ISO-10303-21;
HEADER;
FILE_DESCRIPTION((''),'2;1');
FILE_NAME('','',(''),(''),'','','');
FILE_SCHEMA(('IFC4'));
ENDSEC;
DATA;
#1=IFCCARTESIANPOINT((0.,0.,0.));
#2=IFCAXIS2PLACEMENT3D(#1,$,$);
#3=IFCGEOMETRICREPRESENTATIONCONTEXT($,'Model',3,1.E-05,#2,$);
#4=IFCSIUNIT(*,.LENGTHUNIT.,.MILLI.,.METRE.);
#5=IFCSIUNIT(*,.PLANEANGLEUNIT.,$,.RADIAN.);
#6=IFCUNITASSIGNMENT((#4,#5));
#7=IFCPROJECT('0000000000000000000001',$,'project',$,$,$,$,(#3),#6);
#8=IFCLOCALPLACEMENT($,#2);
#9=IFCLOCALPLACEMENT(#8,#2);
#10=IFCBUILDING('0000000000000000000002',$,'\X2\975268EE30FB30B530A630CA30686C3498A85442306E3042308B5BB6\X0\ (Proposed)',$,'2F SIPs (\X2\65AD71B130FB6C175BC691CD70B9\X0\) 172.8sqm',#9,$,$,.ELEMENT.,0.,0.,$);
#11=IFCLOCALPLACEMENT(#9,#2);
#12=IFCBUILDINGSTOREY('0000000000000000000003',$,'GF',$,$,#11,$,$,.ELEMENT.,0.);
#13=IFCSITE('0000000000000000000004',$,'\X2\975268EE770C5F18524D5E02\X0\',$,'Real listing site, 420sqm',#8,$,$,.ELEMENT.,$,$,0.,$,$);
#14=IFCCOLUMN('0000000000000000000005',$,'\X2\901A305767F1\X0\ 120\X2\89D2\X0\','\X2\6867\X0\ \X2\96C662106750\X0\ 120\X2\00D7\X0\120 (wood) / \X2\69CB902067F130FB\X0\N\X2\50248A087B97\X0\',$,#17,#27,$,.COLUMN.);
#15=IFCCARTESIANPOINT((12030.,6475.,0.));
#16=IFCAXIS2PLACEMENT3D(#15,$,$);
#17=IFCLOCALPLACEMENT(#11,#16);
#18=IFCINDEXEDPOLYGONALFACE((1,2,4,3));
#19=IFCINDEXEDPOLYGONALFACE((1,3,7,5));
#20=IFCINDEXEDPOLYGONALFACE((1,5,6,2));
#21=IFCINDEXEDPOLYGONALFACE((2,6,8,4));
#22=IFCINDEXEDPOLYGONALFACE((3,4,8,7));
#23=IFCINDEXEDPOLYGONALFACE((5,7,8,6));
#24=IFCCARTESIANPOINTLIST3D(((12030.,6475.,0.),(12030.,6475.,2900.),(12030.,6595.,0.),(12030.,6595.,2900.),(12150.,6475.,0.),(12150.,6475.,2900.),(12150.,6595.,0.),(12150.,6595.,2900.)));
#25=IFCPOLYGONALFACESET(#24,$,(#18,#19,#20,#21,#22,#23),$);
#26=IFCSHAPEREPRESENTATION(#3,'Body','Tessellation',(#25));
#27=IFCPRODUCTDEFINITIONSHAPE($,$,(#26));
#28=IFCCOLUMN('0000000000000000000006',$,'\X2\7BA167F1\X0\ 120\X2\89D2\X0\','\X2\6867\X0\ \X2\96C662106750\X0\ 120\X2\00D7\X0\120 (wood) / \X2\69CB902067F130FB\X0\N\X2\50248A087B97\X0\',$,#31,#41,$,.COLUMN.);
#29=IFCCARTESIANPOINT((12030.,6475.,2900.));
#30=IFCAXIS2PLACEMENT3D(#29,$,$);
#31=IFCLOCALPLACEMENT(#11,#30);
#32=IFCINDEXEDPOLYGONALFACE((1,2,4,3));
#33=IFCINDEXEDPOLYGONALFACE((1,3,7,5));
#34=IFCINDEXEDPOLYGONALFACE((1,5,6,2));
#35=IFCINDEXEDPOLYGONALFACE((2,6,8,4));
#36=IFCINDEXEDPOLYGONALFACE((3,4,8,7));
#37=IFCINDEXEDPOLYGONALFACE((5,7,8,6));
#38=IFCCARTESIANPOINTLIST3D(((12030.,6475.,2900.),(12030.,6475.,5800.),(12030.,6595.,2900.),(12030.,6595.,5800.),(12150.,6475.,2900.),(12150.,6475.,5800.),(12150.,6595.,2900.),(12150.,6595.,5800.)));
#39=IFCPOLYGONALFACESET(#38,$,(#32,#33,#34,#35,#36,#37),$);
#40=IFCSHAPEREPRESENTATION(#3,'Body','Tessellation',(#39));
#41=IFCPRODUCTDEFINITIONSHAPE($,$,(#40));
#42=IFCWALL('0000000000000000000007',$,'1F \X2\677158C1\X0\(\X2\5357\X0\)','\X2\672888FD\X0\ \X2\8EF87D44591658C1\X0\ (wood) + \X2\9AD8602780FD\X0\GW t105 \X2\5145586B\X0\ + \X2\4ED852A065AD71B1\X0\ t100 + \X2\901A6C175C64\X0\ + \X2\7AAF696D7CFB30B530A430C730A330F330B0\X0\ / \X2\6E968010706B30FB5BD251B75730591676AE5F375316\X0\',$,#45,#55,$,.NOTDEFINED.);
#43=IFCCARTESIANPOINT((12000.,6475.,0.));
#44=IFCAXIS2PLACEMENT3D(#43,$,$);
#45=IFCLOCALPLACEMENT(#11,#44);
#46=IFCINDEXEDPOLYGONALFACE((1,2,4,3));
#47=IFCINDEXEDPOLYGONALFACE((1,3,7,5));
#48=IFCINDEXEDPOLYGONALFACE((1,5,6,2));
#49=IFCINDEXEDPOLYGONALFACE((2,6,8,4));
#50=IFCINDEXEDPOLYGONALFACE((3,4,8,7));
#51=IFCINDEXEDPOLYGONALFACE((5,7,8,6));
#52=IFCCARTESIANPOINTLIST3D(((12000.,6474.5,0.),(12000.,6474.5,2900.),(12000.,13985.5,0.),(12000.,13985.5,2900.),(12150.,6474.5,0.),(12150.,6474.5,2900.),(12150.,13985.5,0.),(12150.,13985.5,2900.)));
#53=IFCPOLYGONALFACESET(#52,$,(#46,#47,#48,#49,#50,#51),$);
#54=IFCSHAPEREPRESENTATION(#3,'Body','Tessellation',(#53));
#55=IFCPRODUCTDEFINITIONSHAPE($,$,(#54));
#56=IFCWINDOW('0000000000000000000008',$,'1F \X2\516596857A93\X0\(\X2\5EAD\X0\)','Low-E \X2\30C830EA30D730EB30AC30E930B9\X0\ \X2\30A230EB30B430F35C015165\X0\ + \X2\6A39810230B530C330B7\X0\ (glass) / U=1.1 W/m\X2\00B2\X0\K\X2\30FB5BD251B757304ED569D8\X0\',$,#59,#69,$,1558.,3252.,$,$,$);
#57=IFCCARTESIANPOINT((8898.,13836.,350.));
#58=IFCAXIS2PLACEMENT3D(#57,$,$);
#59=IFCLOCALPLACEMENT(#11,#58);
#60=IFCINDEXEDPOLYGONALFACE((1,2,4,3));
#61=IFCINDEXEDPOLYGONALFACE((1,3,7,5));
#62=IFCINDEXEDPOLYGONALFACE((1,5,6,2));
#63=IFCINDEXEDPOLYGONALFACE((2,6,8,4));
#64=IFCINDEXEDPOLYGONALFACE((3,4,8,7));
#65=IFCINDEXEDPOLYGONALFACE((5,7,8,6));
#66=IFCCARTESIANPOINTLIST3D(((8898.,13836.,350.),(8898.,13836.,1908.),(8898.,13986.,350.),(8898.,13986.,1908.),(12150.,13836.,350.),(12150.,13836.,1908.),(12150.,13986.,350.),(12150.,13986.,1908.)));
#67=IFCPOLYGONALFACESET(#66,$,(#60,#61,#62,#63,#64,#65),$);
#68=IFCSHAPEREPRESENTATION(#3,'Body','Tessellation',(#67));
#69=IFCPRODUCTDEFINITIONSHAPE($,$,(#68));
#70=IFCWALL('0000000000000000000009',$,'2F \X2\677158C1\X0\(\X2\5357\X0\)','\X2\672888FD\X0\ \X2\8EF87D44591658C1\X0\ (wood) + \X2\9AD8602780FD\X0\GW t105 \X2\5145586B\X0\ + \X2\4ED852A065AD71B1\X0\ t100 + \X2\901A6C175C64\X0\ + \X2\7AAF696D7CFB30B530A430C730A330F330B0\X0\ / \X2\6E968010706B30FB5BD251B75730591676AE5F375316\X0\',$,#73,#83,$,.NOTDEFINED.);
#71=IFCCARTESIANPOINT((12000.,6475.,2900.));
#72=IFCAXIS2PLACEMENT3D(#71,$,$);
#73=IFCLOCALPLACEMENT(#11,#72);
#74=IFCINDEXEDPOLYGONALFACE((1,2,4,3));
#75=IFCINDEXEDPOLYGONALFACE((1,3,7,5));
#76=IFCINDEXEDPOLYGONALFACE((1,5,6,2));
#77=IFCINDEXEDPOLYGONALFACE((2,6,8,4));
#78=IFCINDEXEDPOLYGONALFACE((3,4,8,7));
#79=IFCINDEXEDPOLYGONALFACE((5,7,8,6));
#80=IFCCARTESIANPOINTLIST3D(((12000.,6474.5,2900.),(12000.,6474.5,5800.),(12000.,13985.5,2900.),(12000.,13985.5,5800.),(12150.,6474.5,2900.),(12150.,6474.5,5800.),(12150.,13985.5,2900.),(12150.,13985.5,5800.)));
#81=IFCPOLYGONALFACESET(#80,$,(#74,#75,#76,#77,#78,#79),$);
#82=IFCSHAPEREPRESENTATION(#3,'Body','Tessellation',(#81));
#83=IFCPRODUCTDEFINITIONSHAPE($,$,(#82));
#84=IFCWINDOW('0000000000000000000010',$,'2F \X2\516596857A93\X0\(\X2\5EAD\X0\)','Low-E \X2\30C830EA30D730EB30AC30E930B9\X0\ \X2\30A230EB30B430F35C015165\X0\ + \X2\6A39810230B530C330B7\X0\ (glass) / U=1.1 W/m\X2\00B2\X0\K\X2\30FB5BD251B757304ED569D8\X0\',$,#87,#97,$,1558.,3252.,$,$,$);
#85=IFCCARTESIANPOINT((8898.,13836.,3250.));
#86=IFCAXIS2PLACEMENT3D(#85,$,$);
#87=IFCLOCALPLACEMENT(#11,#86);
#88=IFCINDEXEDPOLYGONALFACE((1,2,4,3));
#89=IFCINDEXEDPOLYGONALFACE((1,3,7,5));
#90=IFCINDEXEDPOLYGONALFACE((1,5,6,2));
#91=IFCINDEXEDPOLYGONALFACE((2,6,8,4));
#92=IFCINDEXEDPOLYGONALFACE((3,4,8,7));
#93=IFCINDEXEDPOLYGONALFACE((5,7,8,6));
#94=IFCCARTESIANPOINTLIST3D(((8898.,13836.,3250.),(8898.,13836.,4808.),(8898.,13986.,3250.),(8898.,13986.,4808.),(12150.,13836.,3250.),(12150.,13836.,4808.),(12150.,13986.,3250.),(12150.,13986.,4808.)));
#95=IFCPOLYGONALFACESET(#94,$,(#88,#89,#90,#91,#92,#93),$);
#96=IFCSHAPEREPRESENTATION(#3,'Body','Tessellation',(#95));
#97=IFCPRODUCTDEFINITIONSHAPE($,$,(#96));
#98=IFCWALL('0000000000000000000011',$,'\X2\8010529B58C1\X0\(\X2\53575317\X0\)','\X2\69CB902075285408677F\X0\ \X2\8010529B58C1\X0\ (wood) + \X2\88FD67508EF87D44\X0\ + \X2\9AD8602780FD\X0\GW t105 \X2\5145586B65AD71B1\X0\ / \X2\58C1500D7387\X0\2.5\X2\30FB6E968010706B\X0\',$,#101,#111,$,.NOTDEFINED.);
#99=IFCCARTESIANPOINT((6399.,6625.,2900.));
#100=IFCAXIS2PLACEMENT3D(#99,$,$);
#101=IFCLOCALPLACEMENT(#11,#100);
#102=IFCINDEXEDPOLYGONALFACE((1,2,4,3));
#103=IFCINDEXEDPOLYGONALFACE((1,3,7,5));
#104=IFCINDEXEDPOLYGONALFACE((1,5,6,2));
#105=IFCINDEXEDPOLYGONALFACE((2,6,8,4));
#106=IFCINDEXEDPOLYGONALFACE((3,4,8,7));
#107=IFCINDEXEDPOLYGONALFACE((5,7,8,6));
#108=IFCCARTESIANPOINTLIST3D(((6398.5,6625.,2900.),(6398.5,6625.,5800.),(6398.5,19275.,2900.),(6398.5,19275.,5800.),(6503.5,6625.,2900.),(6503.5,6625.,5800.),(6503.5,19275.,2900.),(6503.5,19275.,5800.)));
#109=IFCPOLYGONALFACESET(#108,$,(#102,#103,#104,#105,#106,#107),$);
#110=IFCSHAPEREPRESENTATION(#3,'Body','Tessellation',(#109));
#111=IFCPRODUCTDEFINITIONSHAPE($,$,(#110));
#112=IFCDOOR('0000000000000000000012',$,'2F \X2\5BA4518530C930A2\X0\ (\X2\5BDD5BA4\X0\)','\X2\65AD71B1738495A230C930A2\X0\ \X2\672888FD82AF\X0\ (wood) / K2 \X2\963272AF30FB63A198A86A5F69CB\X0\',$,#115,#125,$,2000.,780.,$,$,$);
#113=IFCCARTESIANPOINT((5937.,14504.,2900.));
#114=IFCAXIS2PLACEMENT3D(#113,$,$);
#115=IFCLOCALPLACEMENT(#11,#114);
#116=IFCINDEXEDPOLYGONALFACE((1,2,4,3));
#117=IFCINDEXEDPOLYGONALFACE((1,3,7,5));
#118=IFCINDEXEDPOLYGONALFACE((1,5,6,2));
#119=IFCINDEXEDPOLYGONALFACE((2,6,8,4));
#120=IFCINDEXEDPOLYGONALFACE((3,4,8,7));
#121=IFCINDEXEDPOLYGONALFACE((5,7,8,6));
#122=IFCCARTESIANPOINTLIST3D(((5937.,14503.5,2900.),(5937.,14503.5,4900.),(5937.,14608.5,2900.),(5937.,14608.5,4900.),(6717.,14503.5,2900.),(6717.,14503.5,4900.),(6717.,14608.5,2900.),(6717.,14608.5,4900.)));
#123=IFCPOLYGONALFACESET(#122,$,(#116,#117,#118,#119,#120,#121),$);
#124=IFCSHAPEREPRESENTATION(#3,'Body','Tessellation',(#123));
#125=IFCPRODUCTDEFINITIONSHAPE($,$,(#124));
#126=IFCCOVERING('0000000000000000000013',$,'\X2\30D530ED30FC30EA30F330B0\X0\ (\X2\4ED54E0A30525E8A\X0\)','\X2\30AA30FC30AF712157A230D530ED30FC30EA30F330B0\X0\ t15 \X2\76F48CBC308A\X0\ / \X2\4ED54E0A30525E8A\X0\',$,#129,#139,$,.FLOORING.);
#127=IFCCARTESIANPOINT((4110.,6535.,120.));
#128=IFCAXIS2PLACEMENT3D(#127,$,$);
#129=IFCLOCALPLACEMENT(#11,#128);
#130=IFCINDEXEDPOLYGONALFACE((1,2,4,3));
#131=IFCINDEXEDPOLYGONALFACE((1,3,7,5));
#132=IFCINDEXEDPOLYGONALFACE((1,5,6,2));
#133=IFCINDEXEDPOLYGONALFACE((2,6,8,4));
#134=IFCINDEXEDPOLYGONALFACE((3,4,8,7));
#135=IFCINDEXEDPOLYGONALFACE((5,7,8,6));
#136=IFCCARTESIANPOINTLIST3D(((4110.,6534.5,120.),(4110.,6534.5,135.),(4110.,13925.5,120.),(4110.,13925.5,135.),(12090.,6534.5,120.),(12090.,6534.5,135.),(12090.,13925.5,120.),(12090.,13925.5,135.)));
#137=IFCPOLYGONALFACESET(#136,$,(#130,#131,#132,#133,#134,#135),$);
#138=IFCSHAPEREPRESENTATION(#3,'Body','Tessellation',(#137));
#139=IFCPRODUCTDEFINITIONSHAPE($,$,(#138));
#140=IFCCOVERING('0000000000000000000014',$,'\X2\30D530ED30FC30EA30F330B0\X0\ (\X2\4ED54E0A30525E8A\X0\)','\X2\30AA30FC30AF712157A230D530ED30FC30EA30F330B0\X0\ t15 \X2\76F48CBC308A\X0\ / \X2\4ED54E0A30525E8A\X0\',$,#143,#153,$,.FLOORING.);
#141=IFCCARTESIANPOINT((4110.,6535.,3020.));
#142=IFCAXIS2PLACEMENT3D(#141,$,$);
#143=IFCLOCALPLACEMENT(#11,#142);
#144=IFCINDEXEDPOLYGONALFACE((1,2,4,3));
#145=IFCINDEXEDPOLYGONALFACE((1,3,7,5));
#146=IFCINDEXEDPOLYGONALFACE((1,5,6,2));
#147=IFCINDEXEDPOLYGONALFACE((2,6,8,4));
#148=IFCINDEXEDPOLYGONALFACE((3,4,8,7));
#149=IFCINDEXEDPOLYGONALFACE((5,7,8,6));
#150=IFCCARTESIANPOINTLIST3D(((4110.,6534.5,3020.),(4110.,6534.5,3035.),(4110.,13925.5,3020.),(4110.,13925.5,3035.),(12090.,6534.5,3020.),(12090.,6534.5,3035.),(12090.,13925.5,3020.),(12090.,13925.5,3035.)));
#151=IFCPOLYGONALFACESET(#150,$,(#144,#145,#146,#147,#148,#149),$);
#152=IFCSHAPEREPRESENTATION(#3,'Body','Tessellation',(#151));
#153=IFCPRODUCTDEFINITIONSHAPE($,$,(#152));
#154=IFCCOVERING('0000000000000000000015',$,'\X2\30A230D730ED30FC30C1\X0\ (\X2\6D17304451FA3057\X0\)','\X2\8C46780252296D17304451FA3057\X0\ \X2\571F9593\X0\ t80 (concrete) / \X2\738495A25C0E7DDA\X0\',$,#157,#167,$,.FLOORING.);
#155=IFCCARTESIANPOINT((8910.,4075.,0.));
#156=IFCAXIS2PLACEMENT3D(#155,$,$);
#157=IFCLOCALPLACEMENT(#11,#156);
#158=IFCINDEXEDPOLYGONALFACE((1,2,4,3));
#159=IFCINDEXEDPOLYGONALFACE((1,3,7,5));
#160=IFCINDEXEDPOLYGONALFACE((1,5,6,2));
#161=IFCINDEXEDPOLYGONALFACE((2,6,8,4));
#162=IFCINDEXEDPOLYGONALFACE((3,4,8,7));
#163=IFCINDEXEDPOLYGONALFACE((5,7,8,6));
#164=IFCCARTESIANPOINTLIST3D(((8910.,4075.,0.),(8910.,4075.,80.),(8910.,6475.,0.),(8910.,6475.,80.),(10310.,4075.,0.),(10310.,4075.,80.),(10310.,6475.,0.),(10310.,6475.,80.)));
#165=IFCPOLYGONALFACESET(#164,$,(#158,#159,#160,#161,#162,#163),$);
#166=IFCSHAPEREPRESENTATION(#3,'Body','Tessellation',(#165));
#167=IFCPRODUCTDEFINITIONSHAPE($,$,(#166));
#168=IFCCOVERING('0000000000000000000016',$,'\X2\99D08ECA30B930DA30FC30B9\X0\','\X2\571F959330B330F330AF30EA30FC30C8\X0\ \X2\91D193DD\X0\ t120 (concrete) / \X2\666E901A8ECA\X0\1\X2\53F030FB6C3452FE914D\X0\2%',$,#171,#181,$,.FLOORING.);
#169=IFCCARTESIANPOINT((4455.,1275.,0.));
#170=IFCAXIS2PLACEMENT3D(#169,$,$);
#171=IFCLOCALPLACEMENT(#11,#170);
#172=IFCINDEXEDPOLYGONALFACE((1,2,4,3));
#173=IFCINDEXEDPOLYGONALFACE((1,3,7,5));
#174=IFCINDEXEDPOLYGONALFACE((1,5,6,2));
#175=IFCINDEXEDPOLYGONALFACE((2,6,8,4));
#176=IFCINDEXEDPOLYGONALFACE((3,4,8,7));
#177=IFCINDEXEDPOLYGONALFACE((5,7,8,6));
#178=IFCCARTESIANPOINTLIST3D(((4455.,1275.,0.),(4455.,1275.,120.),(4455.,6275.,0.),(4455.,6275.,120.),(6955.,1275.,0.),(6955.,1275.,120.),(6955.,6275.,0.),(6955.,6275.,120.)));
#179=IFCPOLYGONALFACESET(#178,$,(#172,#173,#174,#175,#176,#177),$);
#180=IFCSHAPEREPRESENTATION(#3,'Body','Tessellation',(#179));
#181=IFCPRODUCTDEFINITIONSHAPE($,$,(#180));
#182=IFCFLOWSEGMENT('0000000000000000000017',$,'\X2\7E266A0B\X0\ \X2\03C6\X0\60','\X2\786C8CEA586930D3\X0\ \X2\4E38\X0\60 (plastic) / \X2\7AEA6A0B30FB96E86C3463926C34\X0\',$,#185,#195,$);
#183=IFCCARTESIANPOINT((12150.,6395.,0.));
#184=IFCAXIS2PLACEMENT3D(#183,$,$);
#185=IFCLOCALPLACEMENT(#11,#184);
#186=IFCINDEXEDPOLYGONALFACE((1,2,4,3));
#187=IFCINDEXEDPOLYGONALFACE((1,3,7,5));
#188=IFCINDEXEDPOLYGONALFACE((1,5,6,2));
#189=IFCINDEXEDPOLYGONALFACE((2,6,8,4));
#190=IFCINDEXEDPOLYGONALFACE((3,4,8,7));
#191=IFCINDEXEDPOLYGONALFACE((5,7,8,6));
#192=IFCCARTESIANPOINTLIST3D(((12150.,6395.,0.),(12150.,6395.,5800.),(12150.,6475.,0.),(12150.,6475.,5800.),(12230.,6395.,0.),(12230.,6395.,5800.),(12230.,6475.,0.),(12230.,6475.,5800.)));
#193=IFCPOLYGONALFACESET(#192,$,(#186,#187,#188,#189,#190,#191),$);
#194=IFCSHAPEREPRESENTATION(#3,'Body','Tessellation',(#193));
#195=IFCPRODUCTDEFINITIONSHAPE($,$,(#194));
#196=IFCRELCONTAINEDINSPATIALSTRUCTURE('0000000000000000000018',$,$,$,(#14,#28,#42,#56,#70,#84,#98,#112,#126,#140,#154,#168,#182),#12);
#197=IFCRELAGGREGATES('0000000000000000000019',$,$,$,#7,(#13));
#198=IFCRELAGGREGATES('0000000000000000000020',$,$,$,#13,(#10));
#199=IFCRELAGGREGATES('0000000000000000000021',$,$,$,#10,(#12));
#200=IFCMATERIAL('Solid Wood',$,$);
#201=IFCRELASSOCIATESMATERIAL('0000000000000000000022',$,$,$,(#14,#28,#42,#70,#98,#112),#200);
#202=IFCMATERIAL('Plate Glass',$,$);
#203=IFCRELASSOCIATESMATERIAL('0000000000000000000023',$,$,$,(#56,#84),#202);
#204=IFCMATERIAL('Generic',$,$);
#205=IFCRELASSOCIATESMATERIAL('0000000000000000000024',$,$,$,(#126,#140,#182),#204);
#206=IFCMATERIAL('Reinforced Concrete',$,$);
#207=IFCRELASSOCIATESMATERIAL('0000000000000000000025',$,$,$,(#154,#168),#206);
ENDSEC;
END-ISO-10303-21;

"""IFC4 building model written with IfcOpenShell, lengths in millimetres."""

from ifc_helpers import new_model, si_unit, frame, frame_2d, origin, place, context, project, spatial, rectangle, extrude, material, element, fill, save


model = new_model("IFC4")

# Units and contexts
model_context = context("Model", 3, precision=1e-05, world=origin())
ifc_project = project(units=[si_unit("LENGTHUNIT", "METRE", prefix="MILLI"), si_unit("PLANEANGLEUNIT", "RADIAN")], contexts=[model_context])

# Site, building, storey
site_placement = place(None, origin())
site = spatial("IfcSite", under=ifc_project, at=site_placement, Name="青森県弘前市", ObjectType="Real listing site, 420sqm", CompositionType="ELEMENT", RefElevation=0.0)
building_placement = place(site_placement, origin())
building = spatial("IfcBuilding", under=site, at=building_placement, Name="青森・サウナと水風呂のある家 (Proposed)", ObjectType="2F SIPs (断熱・気密重点) 172.8sqm", CompositionType="ELEMENT", ElevationOfRefHeight=0.0, ElevationOfTerrain=0.0)
storey_placement = place(building_placement, origin())
storey = spatial("IfcBuildingStorey", under=building, at=storey_placement, Name="GF", CompositionType="ELEMENT", Elevation=0.0)

# Columns
ifc_material_1 = material(Name="Solid Wood")
column_1_placement = place(storey_placement, frame((12030.0, 6475.0, 0.0)))
element("IfcColumn", 1, at=column_1_placement, inside=storey, material=ifc_material_1, Name="通し柱 120角", Description="桧 集成材 120×120 (wood) / 構造柱・N値計算", PredefinedType="COLUMN", context=model_context, shape_type="SweptSolid", body=[
    extrude(rectangle(XDim=120.0, YDim=120.0, at=frame_2d((60.0, 60.0))), frame((12030.0, 6475.0, 0.0)), (0.0, 0.0, 1.0), 2900.0),
])
column_2_placement = place(storey_placement, frame((12030.0, 6475.0, 2900.0)))
element("IfcColumn", 2, at=column_2_placement, inside=storey, material=ifc_material_1, Name="管柱 120角", Description="桧 集成材 120×120 (wood) / 構造柱・N値計算", PredefinedType="COLUMN", context=model_context, shape_type="SweptSolid", body=[
    extrude(rectangle(XDim=120.0, YDim=120.0, at=frame_2d((60.0, 60.0))), frame((12030.0, 6475.0, 2900.0)), (0.0, 0.0, 1.0), 2900.0),
])

# Wall, opening, window
wall_1_placement = place(storey_placement, frame((12000.0, 6475.0, 0.0)))
wall_1 = element("IfcWall", 3, at=wall_1_placement, inside=storey, material=ifc_material_1, Name="1F 東壁(南)", Description="木製 軸組外壁 (wood) + 高性能GW t105 充填 + 付加断熱 t100 + 通気層 + 窯業系サイディング / 準耐火・寒冷地外皮強化", PredefinedType="NOTDEFINED", context=model_context, shape_type="SweptSolid", body=[
    extrude(rectangle(XDim=150.0, YDim=7511.0, at=frame_2d((75.0, 3755.0))), frame((12000.0, 6475.0, 0.0)), (0.0, 0.0, 1.0), 2900.0),
])
opening_1_placement = place(storey_placement, frame((8898.0, 13836.0, 350.0)))
opening_1 = element("IfcOpeningElement", 4, at=opening_1_placement, cuts=wall_1, PredefinedType="NOTDEFINED", context=model_context, shape_type="SweptSolid", body=[
    extrude(rectangle(XDim=3252.0, YDim=150.0, at=frame_2d((1626.0, 75.0))), frame((8898.0, 13836.0, 350.0)), (0.0, 0.0, 1.0), 1558.0),
])
ifc_material_2 = material(Name="Plate Glass")
window_1_placement = place(storey_placement, frame((8898.0, 13836.0, 350.0)))
window_1 = element("IfcWindow", 5, at=window_1_placement, inside=storey, material=ifc_material_2, Name="1F 入隅窓(庭)", Description="Low-E トリプルガラス アルゴン封入 + 樹脂サッシ (glass) / U=1.1 W/m²K・寒冷地仕様", OverallHeight=1558.0, OverallWidth=3252.0, context=model_context, shape_type="SweptSolid", body=[
    extrude(rectangle(XDim=3252.0, YDim=150.0, at=frame_2d((1626.0, 75.0))), frame((8898.0, 13836.0, 350.0)), (0.0, 0.0, 1.0), 1558.0),
])
fill(opening_1, window_1)

# Wall, opening, window
wall_2_placement = place(storey_placement, frame((12000.0, 6475.0, 2900.0)))
wall_2 = element("IfcWall", 6, at=wall_2_placement, inside=storey, material=ifc_material_1, Name="2F 東壁(南)", Description="木製 軸組外壁 (wood) + 高性能GW t105 充填 + 付加断熱 t100 + 通気層 + 窯業系サイディング / 準耐火・寒冷地外皮強化", PredefinedType="NOTDEFINED", context=model_context, shape_type="SweptSolid", body=[
    extrude(rectangle(XDim=150.0, YDim=7511.0, at=frame_2d((75.0, 3755.0))), frame((12000.0, 6475.0, 2900.0)), (0.0, 0.0, 1.0), 2900.0),
])
opening_2_placement = place(storey_placement, frame((8898.0, 13836.0, 3250.0)))
opening_2 = element("IfcOpeningElement", 7, at=opening_2_placement, cuts=wall_2, PredefinedType="NOTDEFINED", context=model_context, shape_type="SweptSolid", body=[
    extrude(rectangle(XDim=3252.0, YDim=150.0, at=frame_2d((1626.0, 75.0))), frame((8898.0, 13836.0, 3250.0)), (0.0, 0.0, 1.0), 1558.0),
])
window_2_placement = place(storey_placement, frame((8898.0, 13836.0, 3250.0)))
window_2 = element("IfcWindow", 8, at=window_2_placement, inside=storey, material=ifc_material_2, Name="2F 入隅窓(庭)", Description="Low-E トリプルガラス アルゴン封入 + 樹脂サッシ (glass) / U=1.1 W/m²K・寒冷地仕様", OverallHeight=1558.0, OverallWidth=3252.0, context=model_context, shape_type="SweptSolid", body=[
    extrude(rectangle(XDim=3252.0, YDim=150.0, at=frame_2d((1626.0, 75.0))), frame((8898.0, 13836.0, 3250.0)), (0.0, 0.0, 1.0), 1558.0),
])
fill(opening_2, window_2)

# Wall, opening, door
wall_3_placement = place(storey_placement, frame((6399.0, 6625.0, 2900.0)))
wall_3 = element("IfcWall", 9, at=wall_3_placement, inside=storey, material=ifc_material_1, Name="耐力壁(南北)", Description="構造用合板 耐力壁 (wood) + 製材軸組 + 高性能GW t105 充填断熱 / 壁倍率2.5・準耐火", PredefinedType="NOTDEFINED", context=model_context, shape_type="SweptSolid", body=[
    extrude(rectangle(XDim=105.0, YDim=12650.0, at=frame_2d((52.0, 6325.0))), frame((6399.0, 6625.0, 2900.0)), (0.0, 0.0, 1.0), 2900.0),
])
opening_3_placement = place(storey_placement, frame((5937.0, 14504.0, 2900.0)))
opening_3 = element("IfcOpeningElement", 10, at=opening_3_placement, cuts=wall_3, PredefinedType="NOTDEFINED", context=model_context, shape_type="SweptSolid", body=[
    extrude(rectangle(XDim=780.0, YDim=105.0, at=frame_2d((390.0, 52.0))), frame((5937.0, 14504.0, 2900.0)), (0.0, 0.0, 1.0), 2000.0),
])
door_1_placement = place(storey_placement, frame((5937.0, 14504.0, 2900.0)))
door_1 = element("IfcDoor", 11, at=door_1_placement, inside=storey, material=ifc_material_1, Name="2F 室内ドア (寝室)", Description="断熱玄関ドア 木製芯 (wood) / K2 防犯・採風機構", OverallHeight=2000.0, OverallWidth=780.0, context=model_context, shape_type="SweptSolid", body=[
    extrude(rectangle(XDim=780.0, YDim=105.0, at=frame_2d((390.0, 52.0))), frame((5937.0, 14504.0, 2900.0)), (0.0, 0.0, 1.0), 2000.0),
])
fill(opening_3, door_1)

# Coverings
ifc_material_3 = material(Name="Generic")
covering_1_placement = place(storey_placement, frame((4110.0, 6535.0, 120.0)))
element("IfcCovering", 12, at=covering_1_placement, inside=storey, material=ifc_material_3, Name="フローリング (仕上げ床)", Description="オーク無垢フローリング t15 直貼り / 仕上げ床", PredefinedType="FLOORING", context=model_context, shape_type="SweptSolid", body=[
    extrude(rectangle(XDim=7980.0, YDim=7391.0, at=frame_2d((3990.0, 3695.0))), frame((4110.0, 6535.0, 120.0)), (0.0, 0.0, 1.0), 15.0),
])
covering_2_placement = place(storey_placement, frame((4110.0, 6535.0, 3020.0)))
element("IfcCovering", 13, at=covering_2_placement, inside=storey, material=ifc_material_3, Name="フローリング (仕上げ床)", Description="オーク無垢フローリング t15 直貼り / 仕上げ床", PredefinedType="FLOORING", context=model_context, shape_type="SweptSolid", body=[
    extrude(rectangle(XDim=7980.0, YDim=7391.0, at=frame_2d((3990.0, 3695.0))), frame((4110.0, 6535.0, 3020.0)), (0.0, 0.0, 1.0), 15.0),
])
ifc_material_4 = material(Name="Reinforced Concrete")
covering_3_placement = place(storey_placement, frame((8910.0, 4075.0, 0.0)))
element("IfcCovering", 14, at=covering_3_placement, inside=storey, material=ifc_material_4, Name="アプローチ (洗い出し)", Description="豆砂利洗い出し 土間 t80 (concrete) / 玄関導線", PredefinedType="FLOORING", context=model_context, shape_type="SweptSolid", body=[
    extrude(rectangle(XDim=1400.0, YDim=2400.0, at=frame_2d((700.0, 1200.0))), frame((8910.0, 4075.0, 0.0)), (0.0, 0.0, 1.0), 80.0),
])
covering_4_placement = place(storey_placement, frame((4455.0, 1275.0, 0.0)))
element("IfcCovering", 15, at=covering_4_placement, inside=storey, material=ifc_material_4, Name="駐車スペース", Description="土間コンクリート 金鏝 t120 (concrete) / 普通車1台・水勾配2%", PredefinedType="FLOORING", context=model_context, shape_type="SweptSolid", body=[
    extrude(rectangle(XDim=2500.0, YDim=5000.0, at=frame_2d((1250.0, 2500.0))), frame((4455.0, 1275.0, 0.0)), (0.0, 0.0, 1.0), 120.0),
])

# Flow segment
flow_segment_placement = place(storey_placement, frame((12150.0, 6395.0, 0.0)))
element("IfcFlowSegment", 16, at=flow_segment_placement, inside=storey, material=ifc_material_3, Name="縦樋 φ60", Description="硬質塩ビ 丸60 (plastic) / 竪樋・雨水排水", context=model_context, shape_type="SweptSolid", body=[
    extrude(rectangle(XDim=80.0, YDim=80.0, at=frame_2d((40.0, 40.0))), frame((12150.0, 6395.0, 0.0)), (0.0, 0.0, 1.0), 5800.0),
])

save(model, "model.ifc")
